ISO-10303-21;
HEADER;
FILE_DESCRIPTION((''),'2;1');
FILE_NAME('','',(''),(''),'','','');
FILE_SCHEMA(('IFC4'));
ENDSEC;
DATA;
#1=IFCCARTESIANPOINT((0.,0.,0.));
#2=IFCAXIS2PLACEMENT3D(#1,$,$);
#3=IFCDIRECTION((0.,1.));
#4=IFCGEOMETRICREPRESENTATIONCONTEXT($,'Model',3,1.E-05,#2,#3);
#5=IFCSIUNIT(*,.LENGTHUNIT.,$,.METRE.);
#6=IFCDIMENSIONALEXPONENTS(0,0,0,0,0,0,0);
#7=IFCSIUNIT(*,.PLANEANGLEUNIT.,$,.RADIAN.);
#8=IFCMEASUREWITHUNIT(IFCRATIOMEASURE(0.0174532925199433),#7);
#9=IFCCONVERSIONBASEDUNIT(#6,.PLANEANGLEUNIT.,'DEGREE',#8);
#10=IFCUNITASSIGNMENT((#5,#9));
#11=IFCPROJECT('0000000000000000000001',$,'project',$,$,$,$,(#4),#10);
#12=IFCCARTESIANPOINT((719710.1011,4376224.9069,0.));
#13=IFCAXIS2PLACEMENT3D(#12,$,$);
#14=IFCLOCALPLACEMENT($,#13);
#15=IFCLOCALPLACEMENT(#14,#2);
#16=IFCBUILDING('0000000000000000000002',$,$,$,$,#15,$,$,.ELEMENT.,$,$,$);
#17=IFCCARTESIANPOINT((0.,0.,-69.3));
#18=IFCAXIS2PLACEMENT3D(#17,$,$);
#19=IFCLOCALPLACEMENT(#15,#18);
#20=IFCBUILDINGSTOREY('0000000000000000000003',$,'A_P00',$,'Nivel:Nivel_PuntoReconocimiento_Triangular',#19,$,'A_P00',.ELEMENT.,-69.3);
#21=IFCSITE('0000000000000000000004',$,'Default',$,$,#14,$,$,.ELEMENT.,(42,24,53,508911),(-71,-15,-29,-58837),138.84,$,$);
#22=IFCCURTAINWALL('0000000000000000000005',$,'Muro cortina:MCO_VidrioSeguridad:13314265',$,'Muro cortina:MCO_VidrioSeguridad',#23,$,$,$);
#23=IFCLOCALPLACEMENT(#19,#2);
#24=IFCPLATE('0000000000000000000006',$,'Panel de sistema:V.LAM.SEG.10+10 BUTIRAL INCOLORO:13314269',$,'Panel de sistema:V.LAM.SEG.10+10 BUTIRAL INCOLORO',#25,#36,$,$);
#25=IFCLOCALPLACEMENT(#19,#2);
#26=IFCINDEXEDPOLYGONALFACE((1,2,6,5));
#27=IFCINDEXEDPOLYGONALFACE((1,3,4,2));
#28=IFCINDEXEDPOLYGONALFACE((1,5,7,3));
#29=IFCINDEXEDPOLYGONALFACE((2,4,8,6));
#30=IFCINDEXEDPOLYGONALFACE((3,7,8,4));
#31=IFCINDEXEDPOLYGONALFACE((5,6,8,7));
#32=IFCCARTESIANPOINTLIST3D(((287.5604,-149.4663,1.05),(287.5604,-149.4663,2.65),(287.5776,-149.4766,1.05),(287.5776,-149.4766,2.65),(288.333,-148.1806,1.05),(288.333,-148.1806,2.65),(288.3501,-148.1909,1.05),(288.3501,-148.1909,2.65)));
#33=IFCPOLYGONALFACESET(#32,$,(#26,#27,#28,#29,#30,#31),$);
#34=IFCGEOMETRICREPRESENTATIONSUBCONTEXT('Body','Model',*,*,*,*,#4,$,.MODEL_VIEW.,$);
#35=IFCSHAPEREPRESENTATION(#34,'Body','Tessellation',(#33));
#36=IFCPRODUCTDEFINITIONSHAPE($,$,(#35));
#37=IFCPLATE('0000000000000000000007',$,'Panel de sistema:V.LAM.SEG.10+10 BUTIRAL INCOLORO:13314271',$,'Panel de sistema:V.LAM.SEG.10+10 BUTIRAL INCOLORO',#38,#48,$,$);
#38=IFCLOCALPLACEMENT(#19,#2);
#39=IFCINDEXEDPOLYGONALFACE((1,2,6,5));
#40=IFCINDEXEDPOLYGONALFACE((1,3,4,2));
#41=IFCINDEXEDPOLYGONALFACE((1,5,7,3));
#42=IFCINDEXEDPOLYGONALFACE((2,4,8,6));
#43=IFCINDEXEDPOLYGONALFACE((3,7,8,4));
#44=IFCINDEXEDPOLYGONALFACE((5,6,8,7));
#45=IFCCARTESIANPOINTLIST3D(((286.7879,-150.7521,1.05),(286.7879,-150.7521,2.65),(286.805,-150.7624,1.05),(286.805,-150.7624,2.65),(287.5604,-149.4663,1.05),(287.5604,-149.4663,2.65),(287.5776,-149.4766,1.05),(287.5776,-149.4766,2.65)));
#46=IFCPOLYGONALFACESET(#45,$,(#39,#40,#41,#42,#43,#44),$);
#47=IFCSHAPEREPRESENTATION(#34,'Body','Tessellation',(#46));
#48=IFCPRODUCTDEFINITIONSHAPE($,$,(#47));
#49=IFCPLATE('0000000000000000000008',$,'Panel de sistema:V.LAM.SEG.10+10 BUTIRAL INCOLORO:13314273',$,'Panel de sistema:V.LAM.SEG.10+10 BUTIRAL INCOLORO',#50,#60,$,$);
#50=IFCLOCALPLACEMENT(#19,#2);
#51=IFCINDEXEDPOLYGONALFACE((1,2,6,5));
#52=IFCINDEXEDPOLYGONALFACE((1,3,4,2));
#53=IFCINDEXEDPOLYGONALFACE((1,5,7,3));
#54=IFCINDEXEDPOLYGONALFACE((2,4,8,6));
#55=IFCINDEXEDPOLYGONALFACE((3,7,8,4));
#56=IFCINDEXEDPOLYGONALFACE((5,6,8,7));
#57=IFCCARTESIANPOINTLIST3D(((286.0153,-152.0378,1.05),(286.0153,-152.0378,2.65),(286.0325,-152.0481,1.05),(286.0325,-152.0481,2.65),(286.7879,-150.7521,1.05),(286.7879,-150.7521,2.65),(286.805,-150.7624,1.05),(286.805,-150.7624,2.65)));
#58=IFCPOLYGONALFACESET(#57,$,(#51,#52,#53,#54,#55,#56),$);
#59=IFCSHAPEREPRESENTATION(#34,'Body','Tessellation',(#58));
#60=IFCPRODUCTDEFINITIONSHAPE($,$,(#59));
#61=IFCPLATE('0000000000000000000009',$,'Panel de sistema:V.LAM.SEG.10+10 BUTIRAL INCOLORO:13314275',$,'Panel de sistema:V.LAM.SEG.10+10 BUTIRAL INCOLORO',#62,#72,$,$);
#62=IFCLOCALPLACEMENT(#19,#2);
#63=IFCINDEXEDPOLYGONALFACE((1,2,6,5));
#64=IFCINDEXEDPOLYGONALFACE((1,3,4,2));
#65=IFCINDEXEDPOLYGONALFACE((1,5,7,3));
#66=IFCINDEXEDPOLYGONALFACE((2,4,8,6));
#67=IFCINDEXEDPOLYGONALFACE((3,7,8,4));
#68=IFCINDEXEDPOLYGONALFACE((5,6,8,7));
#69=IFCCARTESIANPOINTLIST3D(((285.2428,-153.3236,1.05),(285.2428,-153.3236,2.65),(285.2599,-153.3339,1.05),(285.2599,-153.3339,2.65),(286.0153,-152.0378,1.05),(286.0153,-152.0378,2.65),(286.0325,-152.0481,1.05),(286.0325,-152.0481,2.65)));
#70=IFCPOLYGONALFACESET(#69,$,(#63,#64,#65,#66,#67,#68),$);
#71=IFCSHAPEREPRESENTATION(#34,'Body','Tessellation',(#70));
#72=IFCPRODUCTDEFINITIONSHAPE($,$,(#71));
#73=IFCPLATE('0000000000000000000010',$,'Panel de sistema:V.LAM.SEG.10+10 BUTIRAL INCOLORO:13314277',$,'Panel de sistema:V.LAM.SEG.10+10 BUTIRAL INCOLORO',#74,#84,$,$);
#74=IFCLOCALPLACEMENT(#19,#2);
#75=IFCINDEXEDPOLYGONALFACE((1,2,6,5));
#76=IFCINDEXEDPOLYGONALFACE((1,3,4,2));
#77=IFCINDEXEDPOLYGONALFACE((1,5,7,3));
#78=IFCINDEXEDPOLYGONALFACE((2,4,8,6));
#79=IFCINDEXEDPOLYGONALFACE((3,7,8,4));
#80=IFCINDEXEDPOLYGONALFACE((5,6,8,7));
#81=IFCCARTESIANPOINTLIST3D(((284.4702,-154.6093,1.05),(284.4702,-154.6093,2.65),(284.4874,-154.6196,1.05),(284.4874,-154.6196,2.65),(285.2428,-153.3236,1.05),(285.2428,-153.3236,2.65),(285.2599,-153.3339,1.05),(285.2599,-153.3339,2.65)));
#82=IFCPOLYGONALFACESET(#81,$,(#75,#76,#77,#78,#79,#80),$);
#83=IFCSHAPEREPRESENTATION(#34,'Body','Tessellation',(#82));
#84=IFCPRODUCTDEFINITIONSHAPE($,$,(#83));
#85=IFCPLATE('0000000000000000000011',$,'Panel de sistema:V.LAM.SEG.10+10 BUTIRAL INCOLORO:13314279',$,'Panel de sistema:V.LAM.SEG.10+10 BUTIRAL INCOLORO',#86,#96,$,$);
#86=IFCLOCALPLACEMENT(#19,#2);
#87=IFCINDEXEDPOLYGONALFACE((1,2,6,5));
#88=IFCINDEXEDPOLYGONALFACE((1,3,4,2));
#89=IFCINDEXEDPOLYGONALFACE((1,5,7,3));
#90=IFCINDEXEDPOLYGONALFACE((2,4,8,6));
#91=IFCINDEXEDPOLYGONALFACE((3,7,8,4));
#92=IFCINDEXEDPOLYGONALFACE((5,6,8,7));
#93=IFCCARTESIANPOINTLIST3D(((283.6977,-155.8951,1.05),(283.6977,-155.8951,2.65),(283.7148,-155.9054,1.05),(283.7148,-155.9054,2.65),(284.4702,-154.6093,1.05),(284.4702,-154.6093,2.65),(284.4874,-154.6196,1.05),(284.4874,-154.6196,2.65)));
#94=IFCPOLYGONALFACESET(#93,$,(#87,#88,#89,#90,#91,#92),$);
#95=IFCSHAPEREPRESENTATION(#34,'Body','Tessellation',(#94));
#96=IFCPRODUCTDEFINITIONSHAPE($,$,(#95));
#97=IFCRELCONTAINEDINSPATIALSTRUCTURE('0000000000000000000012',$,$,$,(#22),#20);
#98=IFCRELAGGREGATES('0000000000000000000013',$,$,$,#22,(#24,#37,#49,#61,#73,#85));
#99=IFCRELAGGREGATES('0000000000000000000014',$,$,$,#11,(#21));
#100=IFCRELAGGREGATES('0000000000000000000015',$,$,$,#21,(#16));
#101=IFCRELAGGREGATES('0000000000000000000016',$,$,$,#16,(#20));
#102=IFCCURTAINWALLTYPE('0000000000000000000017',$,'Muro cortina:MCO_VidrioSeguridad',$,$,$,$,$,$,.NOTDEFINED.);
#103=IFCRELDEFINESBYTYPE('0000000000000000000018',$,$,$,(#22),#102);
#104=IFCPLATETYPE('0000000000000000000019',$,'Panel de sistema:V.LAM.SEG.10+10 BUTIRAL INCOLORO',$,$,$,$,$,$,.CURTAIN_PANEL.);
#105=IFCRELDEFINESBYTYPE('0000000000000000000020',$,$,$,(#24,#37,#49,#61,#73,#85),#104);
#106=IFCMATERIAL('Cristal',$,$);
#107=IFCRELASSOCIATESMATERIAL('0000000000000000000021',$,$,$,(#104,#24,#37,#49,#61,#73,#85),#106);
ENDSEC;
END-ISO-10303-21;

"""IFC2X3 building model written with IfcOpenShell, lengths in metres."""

from ifc_helpers import new_model, entity, si_unit, converted_unit, direction, frame, frame_2d, origin, place, context, subcontext, project, spatial, rectangle, extrude, source, transform, mapped, material, type_object, type_shapes, element, aggregate, save


model = new_model("IFC2X3")

# Units and contexts
model_context = context("Model", 3, precision=1e-05, world=origin(), true_north=direction((0.0, 1.0)))
body_context = subcontext(model_context, "Body", "Model", "MODEL_VIEW")
ifc_project = project(units=[si_unit("LENGTHUNIT", "METRE"), converted_unit("PLANEANGLEUNIT", "DEGREE", entity("IfcRatioMeasure", 0.0174532925199433), si_unit("PLANEANGLEUNIT", "RADIAN"), dimensions=[0, 0, 0, 0, 0, 0, 0])], contexts=[model_context])

# Site, building, storey
site_placement = place(None, frame((719710.1011, 4376224.9069, 0.0)))
site = spatial("IfcSite", under=ifc_project, at=site_placement, Name="Default", CompositionType="ELEMENT", RefLatitude=(42, 24, 53, 508911), RefLongitude=(-71, -15, -29, -58837), RefElevation=138.84)
building_placement = place(site_placement, origin())
building = spatial("IfcBuilding", under=site, at=building_placement, CompositionType="ELEMENT")
storey_placement = place(building_placement, frame((0.0, 0.0, -69.3)))
storey = spatial("IfcBuildingStorey", under=building, at=storey_placement, Name="A_P00", ObjectType="Nivel:Nivel_PuntoReconocimiento_Triangular", LongName="A_P00", CompositionType="ELEMENT", Elevation=-69.3)

# Shared definitions
curtain_wall_type = type_object("IfcCurtainWallType", Name="Muro cortina:MCO_VidrioSeguridad", PredefinedType="NOTDEFINED")
ifc_material_1 = material(Name="Cristal")

# Curtain wall, plates
curtain_wall_1_placement = place(storey_placement, frame((0.0, 0.0, 69.3)))
curtain_wall_1 = element("IfcCurtainWall", 1, at=curtain_wall_1_placement, inside=storey, type_object=curtain_wall_type, Name="Muro cortina:MCO_VidrioSeguridad:13314265", ObjectType="Muro cortina:MCO_VidrioSeguridad")
plate_type_1 = type_object("IfcPlateType", Name="Panel de sistema:V.LAM.SEG.10+10 BUTIRAL INCOLORO", PredefinedType="CURTAIN_PANEL", material=ifc_material_1)
shared_shape_1 = source(origin(), body_context, "Body", "SweptSolid", [
    extrude(rectangle(XDim=0.02, YDim=1.5, at=frame_2d((0.0, 0.0), x_axis=(1.0, 0.0))), frame((0.0, 0.0, 0.0), z_axis=(0.0, 0.0, 1.0), x_axis=(0.0, 1.0, 0.0)), (0.0, 0.0, 1.0), 1.6),
])
type_shapes(plate_type_1, [shared_shape_1])
plate_1_placement = place(curtain_wall_1_placement, frame((287.9553, -148.8286, -68.25), z_axis=(0.0, 0.0, 1.0), x_axis=(-0.515038, -0.857167, 0.0)))
plate_1 = element("IfcPlate", 2, at=plate_1_placement, type_object=plate_type_1, material=ifc_material_1, Name="Panel de sistema:V.LAM.SEG.10+10 BUTIRAL INCOLORO:13314269", ObjectType="Panel de sistema:V.LAM.SEG.10+10 BUTIRAL INCOLORO", context=body_context, shape_type="MappedRepresentation", body=[
    mapped(shared_shape_1, transform((0.0, 0.0, 0.0), scale=1.0)),
])
plate_2_placement = place(curtain_wall_1_placement, frame((287.1827, -150.1143, -68.25), z_axis=(0.0, 0.0, 1.0), x_axis=(-0.515038, -0.857167, 0.0)))
plate_2 = element("IfcPlate", 3, at=plate_2_placement, type_object=plate_type_1, material=ifc_material_1, Name="Panel de sistema:V.LAM.SEG.10+10 BUTIRAL INCOLORO:13314271", ObjectType="Panel de sistema:V.LAM.SEG.10+10 BUTIRAL INCOLORO", context=body_context, shape_type="MappedRepresentation", body=[
    mapped(shared_shape_1, transform((0.0, 0.0, 0.0), scale=1.0)),
])
plate_3_placement = place(curtain_wall_1_placement, frame((286.4102, -151.4001, -68.25), z_axis=(0.0, 0.0, 1.0), x_axis=(-0.515038, -0.857167, 0.0)))
plate_3 = element("IfcPlate", 4, at=plate_3_placement, type_object=plate_type_1, material=ifc_material_1, Name="Panel de sistema:V.LAM.SEG.10+10 BUTIRAL INCOLORO:13314273", ObjectType="Panel de sistema:V.LAM.SEG.10+10 BUTIRAL INCOLORO", context=body_context, shape_type="MappedRepresentation", body=[
    mapped(shared_shape_1, transform((0.0, 0.0, 0.0), scale=1.0)),
])
plate_4_placement = place(curtain_wall_1_placement, frame((285.6376, -152.6858, -68.25), z_axis=(0.0, 0.0, 1.0), x_axis=(-0.515038, -0.857167, 0.0)))
plate_4 = element("IfcPlate", 5, at=plate_4_placement, type_object=plate_type_1, material=ifc_material_1, Name="Panel de sistema:V.LAM.SEG.10+10 BUTIRAL INCOLORO:13314275", ObjectType="Panel de sistema:V.LAM.SEG.10+10 BUTIRAL INCOLORO", context=body_context, shape_type="MappedRepresentation", body=[
    mapped(shared_shape_1, transform((0.0, 0.0, 0.0), scale=1.0)),
])
plate_5_placement = place(curtain_wall_1_placement, frame((284.8651, -153.9716, -68.25), z_axis=(0.0, 0.0, 1.0), x_axis=(-0.515038, -0.857167, 0.0)))
plate_5 = element("IfcPlate", 6, at=plate_5_placement, type_object=plate_type_1, material=ifc_material_1, Name="Panel de sistema:V.LAM.SEG.10+10 BUTIRAL INCOLORO:13314277", ObjectType="Panel de sistema:V.LAM.SEG.10+10 BUTIRAL INCOLORO", context=body_context, shape_type="MappedRepresentation", body=[
    mapped(shared_shape_1, transform((0.0, 0.0, 0.0), scale=1.0)),
])
plate_6_placement = place(curtain_wall_1_placement, frame((284.0925, -155.2573, -68.25), z_axis=(0.0, 0.0, 1.0), x_axis=(-0.515038, -0.857167, 0.0)))
plate_6 = element("IfcPlate", 7, at=plate_6_placement, type_object=plate_type_1, material=ifc_material_1, Name="Panel de sistema:V.LAM.SEG.10+10 BUTIRAL INCOLORO:13314279", ObjectType="Panel de sistema:V.LAM.SEG.10+10 BUTIRAL INCOLORO", context=body_context, shape_type="MappedRepresentation", body=[
    mapped(shared_shape_1, transform((0.0, 0.0, 0.0), scale=1.0)),
])
aggregate(curtain_wall_1, [plate_1, plate_2, plate_3, plate_4, plate_5, plate_6])

save(model, "model.ifc")
